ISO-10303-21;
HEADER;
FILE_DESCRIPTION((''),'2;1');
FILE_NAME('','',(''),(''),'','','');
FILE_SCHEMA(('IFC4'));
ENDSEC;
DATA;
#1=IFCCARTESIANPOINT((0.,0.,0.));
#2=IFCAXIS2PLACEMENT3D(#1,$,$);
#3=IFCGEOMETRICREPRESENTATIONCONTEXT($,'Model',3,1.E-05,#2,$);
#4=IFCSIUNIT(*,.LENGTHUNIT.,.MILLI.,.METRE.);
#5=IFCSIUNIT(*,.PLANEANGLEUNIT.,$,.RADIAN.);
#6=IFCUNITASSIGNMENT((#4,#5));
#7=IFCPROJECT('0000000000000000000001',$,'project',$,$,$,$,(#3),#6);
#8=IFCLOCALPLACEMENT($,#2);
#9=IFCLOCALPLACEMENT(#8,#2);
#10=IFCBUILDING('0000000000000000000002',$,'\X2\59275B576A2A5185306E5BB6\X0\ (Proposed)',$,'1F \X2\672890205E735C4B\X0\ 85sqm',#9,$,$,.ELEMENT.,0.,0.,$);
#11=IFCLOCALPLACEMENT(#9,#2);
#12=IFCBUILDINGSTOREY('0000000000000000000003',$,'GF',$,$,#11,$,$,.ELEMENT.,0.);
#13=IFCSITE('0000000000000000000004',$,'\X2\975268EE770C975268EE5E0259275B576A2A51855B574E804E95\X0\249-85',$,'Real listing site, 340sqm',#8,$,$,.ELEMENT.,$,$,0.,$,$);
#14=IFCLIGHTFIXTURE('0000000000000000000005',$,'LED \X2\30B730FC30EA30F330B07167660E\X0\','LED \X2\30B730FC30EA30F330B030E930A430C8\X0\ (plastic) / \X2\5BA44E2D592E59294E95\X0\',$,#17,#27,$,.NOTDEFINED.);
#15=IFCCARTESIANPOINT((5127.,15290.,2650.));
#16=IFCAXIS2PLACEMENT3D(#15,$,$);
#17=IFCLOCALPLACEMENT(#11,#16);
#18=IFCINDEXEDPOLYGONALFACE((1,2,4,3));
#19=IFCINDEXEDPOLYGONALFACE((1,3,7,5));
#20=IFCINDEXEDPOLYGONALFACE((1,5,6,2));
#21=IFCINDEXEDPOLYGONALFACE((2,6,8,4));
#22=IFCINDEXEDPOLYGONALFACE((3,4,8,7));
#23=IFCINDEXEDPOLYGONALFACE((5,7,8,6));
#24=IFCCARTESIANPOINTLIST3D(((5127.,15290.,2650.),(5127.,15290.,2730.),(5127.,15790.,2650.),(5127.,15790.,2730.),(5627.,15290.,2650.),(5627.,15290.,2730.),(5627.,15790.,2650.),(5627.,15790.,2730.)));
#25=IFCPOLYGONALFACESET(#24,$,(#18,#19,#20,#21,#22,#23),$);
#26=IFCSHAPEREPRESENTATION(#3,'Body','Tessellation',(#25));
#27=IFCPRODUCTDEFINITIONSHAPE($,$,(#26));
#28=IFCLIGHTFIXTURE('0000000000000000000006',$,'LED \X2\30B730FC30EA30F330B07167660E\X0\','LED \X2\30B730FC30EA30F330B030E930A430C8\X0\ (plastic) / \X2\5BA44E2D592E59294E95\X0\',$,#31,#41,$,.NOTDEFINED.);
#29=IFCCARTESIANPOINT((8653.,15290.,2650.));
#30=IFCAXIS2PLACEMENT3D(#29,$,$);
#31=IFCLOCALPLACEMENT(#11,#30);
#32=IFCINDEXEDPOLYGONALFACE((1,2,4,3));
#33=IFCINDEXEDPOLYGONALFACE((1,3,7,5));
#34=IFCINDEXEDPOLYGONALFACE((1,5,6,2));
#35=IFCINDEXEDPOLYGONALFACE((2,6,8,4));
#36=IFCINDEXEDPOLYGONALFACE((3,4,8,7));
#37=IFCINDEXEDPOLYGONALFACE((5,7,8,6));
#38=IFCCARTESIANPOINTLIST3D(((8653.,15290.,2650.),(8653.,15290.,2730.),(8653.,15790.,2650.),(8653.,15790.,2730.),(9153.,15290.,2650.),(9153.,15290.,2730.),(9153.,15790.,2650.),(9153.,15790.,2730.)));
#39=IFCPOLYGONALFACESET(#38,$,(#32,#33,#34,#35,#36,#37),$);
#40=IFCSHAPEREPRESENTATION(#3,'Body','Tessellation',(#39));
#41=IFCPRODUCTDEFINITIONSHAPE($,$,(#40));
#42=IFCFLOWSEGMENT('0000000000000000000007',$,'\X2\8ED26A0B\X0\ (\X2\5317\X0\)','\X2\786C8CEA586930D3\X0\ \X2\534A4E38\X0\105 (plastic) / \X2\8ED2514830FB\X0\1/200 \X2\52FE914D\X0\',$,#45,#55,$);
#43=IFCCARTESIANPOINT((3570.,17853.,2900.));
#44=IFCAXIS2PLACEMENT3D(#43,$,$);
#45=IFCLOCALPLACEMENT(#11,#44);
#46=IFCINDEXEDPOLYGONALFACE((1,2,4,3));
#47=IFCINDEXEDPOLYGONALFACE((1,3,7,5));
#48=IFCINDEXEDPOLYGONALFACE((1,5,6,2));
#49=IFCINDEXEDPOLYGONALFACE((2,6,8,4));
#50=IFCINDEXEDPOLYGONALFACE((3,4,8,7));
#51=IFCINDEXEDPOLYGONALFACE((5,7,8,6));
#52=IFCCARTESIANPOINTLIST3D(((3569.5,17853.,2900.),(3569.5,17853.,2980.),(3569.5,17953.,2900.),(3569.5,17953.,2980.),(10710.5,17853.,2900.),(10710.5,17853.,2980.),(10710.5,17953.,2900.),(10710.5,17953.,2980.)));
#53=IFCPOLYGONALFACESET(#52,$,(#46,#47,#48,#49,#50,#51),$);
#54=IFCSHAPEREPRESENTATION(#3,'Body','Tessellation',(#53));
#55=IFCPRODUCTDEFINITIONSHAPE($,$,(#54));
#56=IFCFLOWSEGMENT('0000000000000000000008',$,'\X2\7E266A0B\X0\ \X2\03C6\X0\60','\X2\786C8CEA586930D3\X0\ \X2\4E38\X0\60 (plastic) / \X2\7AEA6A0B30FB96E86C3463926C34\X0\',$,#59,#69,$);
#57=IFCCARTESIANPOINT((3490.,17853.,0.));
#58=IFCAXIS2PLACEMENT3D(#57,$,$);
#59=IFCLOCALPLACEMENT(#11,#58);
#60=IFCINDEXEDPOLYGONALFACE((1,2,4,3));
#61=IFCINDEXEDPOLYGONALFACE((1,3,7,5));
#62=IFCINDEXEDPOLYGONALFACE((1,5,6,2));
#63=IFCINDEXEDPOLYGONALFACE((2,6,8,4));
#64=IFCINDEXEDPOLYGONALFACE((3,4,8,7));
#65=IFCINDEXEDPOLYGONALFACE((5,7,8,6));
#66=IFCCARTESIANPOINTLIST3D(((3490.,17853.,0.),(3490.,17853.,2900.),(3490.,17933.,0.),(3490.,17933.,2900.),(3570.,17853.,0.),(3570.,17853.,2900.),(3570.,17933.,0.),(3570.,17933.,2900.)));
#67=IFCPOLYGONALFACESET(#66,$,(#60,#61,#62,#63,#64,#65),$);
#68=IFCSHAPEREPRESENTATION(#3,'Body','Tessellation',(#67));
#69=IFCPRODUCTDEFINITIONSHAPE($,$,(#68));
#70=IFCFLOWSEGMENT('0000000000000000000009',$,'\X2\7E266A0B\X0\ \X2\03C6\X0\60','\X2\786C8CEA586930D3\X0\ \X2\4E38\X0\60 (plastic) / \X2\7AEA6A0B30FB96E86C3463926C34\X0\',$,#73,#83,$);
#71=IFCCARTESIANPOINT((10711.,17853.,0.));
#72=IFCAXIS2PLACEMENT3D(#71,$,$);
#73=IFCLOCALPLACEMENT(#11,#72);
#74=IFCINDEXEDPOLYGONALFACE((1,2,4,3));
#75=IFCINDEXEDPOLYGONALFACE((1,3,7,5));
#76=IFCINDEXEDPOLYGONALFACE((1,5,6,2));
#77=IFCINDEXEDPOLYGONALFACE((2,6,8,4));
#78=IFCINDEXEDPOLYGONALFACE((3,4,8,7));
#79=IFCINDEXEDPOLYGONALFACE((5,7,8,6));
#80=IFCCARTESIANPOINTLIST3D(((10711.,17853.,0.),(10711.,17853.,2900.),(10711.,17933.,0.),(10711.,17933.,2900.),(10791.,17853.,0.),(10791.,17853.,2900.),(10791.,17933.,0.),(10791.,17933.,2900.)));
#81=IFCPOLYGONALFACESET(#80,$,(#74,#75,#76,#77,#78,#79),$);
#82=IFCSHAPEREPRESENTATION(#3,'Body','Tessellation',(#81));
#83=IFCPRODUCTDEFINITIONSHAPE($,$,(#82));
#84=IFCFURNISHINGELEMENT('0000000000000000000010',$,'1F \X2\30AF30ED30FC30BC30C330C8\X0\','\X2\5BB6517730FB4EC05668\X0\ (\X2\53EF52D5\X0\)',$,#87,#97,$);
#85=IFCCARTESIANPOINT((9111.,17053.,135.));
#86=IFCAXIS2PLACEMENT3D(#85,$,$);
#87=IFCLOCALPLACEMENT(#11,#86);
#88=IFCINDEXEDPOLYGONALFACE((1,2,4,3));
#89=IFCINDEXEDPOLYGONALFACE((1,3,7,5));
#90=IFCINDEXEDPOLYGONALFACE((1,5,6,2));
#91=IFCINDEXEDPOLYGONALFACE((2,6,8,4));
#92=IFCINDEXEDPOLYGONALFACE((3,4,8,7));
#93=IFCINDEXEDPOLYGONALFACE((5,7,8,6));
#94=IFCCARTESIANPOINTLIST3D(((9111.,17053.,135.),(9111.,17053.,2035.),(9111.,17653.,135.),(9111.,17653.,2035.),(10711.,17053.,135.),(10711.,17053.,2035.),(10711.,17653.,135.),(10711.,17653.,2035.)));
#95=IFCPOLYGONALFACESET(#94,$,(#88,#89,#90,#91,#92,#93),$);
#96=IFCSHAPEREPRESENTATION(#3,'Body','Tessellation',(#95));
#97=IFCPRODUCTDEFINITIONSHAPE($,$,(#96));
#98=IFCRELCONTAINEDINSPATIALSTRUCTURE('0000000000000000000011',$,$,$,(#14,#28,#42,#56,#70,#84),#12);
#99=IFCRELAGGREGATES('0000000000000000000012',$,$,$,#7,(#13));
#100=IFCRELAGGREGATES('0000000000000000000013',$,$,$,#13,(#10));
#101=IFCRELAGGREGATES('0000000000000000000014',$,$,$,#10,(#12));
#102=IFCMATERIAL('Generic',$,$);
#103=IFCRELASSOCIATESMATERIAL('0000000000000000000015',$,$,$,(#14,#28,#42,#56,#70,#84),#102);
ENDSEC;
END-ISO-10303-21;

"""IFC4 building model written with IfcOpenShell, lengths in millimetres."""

from ifc_helpers import new_model, si_unit, frame, frame_2d, origin, place, context, project, spatial, rectangle, extrude, material, element, save


model = new_model("IFC4")

# Units and contexts
model_context = context("Model", 3, precision=1e-05, world=origin())
ifc_project = project(units=[si_unit("LENGTHUNIT", "METRE", prefix="MILLI"), si_unit("PLANEANGLEUNIT", "RADIAN")], contexts=[model_context])

# Site, building, storey
site_placement = place(None, origin())
site = spatial("IfcSite", under=ifc_project, at=site_placement, Name="青森県青森市大字横内字亀井249-85", ObjectType="Real listing site, 340sqm", CompositionType="ELEMENT", RefElevation=0.0)
building_placement = place(site_placement, origin())
building = spatial("IfcBuilding", under=site, at=building_placement, Name="大字横内の家 (Proposed)", ObjectType="1F 木造平屋 85sqm", CompositionType="ELEMENT", ElevationOfRefHeight=0.0, ElevationOfTerrain=0.0)
storey_placement = place(building_placement, origin())
storey = spatial("IfcBuildingStorey", under=building, at=storey_placement, Name="GF", CompositionType="ELEMENT", Elevation=0.0)

# Shared definitions
ifc_material_1 = material(Name="Generic")

# Light fixtures
light_fixture_1_placement = place(storey_placement, frame((5127.0, 15290.0, 2650.0)))
element("IfcLightFixture", 1, at=light_fixture_1_placement, inside=storey, material=ifc_material_1, Name="LED シーリング照明", Description="LED シーリングライト (plastic) / 室中央天井", PredefinedType="NOTDEFINED", context=model_context, shape_type="SweptSolid", body=[
    extrude(rectangle(XDim=500.0, YDim=500.0, at=frame_2d((250.0, 250.0))), frame((5127.0, 15290.0, 2650.0)), (0.0, 0.0, 1.0), 80.0),
])
light_fixture_2_placement = place(storey_placement, frame((8653.0, 15290.0, 2650.0)))
element("IfcLightFixture", 2, at=light_fixture_2_placement, inside=storey, material=ifc_material_1, Name="LED シーリング照明", Description="LED シーリングライト (plastic) / 室中央天井", PredefinedType="NOTDEFINED", context=model_context, shape_type="SweptSolid", body=[
    extrude(rectangle(XDim=500.0, YDim=500.0, at=frame_2d((250.0, 250.0))), frame((8653.0, 15290.0, 2650.0)), (0.0, 0.0, 1.0), 80.0),
])

# Flow segments
flow_segment_1_placement = place(storey_placement, frame((3570.0, 17853.0, 2900.0)))
element("IfcFlowSegment", 3, at=flow_segment_1_placement, inside=storey, material=ifc_material_1, Name="軒樋 (北)", Description="硬質塩ビ 半丸105 (plastic) / 軒先・1/200 勾配", context=model_context, shape_type="SweptSolid", body=[
    extrude(rectangle(XDim=7141.0, YDim=100.0, at=frame_2d((3570.0, 50.0))), frame((3570.0, 17853.0, 2900.0)), (0.0, 0.0, 1.0), 80.0),
])
flow_segment_2_placement = place(storey_placement, frame((3490.0, 17853.0, 0.0)))
element("IfcFlowSegment", 4, at=flow_segment_2_placement, inside=storey, material=ifc_material_1, Name="縦樋 φ60", Description="硬質塩ビ 丸60 (plastic) / 竪樋・雨水排水", context=model_context, shape_type="SweptSolid", body=[
    extrude(rectangle(XDim=80.0, YDim=80.0, at=frame_2d((40.0, 40.0))), frame((3490.0, 17853.0, 0.0)), (0.0, 0.0, 1.0), 2900.0),
])
flow_segment_3_placement = place(storey_placement, frame((10711.0, 17853.0, 0.0)))
element("IfcFlowSegment", 5, at=flow_segment_3_placement, inside=storey, material=ifc_material_1, Name="縦樋 φ60", Description="硬質塩ビ 丸60 (plastic) / 竪樋・雨水排水", context=model_context, shape_type="SweptSolid", body=[
    extrude(rectangle(XDim=80.0, YDim=80.0, at=frame_2d((40.0, 40.0))), frame((10711.0, 17853.0, 0.0)), (0.0, 0.0, 1.0), 2900.0),
])

# Furnishing element
furnishing_placement = place(storey_placement, frame((9111.0, 17053.0, 135.0)))
element("IfcFurnishingElement", 6, at=furnishing_placement, inside=storey, material=ifc_material_1, Name="1F クローゼット", Description="家具・什器 (可動)", context=model_context, shape_type="SweptSolid", body=[
    extrude(rectangle(XDim=1600.0, YDim=600.0, at=frame_2d((800.0, 300.0))), frame((9111.0, 17053.0, 135.0)), (0.0, 0.0, 1.0), 1900.0),
])

save(model, "model.ifc")
